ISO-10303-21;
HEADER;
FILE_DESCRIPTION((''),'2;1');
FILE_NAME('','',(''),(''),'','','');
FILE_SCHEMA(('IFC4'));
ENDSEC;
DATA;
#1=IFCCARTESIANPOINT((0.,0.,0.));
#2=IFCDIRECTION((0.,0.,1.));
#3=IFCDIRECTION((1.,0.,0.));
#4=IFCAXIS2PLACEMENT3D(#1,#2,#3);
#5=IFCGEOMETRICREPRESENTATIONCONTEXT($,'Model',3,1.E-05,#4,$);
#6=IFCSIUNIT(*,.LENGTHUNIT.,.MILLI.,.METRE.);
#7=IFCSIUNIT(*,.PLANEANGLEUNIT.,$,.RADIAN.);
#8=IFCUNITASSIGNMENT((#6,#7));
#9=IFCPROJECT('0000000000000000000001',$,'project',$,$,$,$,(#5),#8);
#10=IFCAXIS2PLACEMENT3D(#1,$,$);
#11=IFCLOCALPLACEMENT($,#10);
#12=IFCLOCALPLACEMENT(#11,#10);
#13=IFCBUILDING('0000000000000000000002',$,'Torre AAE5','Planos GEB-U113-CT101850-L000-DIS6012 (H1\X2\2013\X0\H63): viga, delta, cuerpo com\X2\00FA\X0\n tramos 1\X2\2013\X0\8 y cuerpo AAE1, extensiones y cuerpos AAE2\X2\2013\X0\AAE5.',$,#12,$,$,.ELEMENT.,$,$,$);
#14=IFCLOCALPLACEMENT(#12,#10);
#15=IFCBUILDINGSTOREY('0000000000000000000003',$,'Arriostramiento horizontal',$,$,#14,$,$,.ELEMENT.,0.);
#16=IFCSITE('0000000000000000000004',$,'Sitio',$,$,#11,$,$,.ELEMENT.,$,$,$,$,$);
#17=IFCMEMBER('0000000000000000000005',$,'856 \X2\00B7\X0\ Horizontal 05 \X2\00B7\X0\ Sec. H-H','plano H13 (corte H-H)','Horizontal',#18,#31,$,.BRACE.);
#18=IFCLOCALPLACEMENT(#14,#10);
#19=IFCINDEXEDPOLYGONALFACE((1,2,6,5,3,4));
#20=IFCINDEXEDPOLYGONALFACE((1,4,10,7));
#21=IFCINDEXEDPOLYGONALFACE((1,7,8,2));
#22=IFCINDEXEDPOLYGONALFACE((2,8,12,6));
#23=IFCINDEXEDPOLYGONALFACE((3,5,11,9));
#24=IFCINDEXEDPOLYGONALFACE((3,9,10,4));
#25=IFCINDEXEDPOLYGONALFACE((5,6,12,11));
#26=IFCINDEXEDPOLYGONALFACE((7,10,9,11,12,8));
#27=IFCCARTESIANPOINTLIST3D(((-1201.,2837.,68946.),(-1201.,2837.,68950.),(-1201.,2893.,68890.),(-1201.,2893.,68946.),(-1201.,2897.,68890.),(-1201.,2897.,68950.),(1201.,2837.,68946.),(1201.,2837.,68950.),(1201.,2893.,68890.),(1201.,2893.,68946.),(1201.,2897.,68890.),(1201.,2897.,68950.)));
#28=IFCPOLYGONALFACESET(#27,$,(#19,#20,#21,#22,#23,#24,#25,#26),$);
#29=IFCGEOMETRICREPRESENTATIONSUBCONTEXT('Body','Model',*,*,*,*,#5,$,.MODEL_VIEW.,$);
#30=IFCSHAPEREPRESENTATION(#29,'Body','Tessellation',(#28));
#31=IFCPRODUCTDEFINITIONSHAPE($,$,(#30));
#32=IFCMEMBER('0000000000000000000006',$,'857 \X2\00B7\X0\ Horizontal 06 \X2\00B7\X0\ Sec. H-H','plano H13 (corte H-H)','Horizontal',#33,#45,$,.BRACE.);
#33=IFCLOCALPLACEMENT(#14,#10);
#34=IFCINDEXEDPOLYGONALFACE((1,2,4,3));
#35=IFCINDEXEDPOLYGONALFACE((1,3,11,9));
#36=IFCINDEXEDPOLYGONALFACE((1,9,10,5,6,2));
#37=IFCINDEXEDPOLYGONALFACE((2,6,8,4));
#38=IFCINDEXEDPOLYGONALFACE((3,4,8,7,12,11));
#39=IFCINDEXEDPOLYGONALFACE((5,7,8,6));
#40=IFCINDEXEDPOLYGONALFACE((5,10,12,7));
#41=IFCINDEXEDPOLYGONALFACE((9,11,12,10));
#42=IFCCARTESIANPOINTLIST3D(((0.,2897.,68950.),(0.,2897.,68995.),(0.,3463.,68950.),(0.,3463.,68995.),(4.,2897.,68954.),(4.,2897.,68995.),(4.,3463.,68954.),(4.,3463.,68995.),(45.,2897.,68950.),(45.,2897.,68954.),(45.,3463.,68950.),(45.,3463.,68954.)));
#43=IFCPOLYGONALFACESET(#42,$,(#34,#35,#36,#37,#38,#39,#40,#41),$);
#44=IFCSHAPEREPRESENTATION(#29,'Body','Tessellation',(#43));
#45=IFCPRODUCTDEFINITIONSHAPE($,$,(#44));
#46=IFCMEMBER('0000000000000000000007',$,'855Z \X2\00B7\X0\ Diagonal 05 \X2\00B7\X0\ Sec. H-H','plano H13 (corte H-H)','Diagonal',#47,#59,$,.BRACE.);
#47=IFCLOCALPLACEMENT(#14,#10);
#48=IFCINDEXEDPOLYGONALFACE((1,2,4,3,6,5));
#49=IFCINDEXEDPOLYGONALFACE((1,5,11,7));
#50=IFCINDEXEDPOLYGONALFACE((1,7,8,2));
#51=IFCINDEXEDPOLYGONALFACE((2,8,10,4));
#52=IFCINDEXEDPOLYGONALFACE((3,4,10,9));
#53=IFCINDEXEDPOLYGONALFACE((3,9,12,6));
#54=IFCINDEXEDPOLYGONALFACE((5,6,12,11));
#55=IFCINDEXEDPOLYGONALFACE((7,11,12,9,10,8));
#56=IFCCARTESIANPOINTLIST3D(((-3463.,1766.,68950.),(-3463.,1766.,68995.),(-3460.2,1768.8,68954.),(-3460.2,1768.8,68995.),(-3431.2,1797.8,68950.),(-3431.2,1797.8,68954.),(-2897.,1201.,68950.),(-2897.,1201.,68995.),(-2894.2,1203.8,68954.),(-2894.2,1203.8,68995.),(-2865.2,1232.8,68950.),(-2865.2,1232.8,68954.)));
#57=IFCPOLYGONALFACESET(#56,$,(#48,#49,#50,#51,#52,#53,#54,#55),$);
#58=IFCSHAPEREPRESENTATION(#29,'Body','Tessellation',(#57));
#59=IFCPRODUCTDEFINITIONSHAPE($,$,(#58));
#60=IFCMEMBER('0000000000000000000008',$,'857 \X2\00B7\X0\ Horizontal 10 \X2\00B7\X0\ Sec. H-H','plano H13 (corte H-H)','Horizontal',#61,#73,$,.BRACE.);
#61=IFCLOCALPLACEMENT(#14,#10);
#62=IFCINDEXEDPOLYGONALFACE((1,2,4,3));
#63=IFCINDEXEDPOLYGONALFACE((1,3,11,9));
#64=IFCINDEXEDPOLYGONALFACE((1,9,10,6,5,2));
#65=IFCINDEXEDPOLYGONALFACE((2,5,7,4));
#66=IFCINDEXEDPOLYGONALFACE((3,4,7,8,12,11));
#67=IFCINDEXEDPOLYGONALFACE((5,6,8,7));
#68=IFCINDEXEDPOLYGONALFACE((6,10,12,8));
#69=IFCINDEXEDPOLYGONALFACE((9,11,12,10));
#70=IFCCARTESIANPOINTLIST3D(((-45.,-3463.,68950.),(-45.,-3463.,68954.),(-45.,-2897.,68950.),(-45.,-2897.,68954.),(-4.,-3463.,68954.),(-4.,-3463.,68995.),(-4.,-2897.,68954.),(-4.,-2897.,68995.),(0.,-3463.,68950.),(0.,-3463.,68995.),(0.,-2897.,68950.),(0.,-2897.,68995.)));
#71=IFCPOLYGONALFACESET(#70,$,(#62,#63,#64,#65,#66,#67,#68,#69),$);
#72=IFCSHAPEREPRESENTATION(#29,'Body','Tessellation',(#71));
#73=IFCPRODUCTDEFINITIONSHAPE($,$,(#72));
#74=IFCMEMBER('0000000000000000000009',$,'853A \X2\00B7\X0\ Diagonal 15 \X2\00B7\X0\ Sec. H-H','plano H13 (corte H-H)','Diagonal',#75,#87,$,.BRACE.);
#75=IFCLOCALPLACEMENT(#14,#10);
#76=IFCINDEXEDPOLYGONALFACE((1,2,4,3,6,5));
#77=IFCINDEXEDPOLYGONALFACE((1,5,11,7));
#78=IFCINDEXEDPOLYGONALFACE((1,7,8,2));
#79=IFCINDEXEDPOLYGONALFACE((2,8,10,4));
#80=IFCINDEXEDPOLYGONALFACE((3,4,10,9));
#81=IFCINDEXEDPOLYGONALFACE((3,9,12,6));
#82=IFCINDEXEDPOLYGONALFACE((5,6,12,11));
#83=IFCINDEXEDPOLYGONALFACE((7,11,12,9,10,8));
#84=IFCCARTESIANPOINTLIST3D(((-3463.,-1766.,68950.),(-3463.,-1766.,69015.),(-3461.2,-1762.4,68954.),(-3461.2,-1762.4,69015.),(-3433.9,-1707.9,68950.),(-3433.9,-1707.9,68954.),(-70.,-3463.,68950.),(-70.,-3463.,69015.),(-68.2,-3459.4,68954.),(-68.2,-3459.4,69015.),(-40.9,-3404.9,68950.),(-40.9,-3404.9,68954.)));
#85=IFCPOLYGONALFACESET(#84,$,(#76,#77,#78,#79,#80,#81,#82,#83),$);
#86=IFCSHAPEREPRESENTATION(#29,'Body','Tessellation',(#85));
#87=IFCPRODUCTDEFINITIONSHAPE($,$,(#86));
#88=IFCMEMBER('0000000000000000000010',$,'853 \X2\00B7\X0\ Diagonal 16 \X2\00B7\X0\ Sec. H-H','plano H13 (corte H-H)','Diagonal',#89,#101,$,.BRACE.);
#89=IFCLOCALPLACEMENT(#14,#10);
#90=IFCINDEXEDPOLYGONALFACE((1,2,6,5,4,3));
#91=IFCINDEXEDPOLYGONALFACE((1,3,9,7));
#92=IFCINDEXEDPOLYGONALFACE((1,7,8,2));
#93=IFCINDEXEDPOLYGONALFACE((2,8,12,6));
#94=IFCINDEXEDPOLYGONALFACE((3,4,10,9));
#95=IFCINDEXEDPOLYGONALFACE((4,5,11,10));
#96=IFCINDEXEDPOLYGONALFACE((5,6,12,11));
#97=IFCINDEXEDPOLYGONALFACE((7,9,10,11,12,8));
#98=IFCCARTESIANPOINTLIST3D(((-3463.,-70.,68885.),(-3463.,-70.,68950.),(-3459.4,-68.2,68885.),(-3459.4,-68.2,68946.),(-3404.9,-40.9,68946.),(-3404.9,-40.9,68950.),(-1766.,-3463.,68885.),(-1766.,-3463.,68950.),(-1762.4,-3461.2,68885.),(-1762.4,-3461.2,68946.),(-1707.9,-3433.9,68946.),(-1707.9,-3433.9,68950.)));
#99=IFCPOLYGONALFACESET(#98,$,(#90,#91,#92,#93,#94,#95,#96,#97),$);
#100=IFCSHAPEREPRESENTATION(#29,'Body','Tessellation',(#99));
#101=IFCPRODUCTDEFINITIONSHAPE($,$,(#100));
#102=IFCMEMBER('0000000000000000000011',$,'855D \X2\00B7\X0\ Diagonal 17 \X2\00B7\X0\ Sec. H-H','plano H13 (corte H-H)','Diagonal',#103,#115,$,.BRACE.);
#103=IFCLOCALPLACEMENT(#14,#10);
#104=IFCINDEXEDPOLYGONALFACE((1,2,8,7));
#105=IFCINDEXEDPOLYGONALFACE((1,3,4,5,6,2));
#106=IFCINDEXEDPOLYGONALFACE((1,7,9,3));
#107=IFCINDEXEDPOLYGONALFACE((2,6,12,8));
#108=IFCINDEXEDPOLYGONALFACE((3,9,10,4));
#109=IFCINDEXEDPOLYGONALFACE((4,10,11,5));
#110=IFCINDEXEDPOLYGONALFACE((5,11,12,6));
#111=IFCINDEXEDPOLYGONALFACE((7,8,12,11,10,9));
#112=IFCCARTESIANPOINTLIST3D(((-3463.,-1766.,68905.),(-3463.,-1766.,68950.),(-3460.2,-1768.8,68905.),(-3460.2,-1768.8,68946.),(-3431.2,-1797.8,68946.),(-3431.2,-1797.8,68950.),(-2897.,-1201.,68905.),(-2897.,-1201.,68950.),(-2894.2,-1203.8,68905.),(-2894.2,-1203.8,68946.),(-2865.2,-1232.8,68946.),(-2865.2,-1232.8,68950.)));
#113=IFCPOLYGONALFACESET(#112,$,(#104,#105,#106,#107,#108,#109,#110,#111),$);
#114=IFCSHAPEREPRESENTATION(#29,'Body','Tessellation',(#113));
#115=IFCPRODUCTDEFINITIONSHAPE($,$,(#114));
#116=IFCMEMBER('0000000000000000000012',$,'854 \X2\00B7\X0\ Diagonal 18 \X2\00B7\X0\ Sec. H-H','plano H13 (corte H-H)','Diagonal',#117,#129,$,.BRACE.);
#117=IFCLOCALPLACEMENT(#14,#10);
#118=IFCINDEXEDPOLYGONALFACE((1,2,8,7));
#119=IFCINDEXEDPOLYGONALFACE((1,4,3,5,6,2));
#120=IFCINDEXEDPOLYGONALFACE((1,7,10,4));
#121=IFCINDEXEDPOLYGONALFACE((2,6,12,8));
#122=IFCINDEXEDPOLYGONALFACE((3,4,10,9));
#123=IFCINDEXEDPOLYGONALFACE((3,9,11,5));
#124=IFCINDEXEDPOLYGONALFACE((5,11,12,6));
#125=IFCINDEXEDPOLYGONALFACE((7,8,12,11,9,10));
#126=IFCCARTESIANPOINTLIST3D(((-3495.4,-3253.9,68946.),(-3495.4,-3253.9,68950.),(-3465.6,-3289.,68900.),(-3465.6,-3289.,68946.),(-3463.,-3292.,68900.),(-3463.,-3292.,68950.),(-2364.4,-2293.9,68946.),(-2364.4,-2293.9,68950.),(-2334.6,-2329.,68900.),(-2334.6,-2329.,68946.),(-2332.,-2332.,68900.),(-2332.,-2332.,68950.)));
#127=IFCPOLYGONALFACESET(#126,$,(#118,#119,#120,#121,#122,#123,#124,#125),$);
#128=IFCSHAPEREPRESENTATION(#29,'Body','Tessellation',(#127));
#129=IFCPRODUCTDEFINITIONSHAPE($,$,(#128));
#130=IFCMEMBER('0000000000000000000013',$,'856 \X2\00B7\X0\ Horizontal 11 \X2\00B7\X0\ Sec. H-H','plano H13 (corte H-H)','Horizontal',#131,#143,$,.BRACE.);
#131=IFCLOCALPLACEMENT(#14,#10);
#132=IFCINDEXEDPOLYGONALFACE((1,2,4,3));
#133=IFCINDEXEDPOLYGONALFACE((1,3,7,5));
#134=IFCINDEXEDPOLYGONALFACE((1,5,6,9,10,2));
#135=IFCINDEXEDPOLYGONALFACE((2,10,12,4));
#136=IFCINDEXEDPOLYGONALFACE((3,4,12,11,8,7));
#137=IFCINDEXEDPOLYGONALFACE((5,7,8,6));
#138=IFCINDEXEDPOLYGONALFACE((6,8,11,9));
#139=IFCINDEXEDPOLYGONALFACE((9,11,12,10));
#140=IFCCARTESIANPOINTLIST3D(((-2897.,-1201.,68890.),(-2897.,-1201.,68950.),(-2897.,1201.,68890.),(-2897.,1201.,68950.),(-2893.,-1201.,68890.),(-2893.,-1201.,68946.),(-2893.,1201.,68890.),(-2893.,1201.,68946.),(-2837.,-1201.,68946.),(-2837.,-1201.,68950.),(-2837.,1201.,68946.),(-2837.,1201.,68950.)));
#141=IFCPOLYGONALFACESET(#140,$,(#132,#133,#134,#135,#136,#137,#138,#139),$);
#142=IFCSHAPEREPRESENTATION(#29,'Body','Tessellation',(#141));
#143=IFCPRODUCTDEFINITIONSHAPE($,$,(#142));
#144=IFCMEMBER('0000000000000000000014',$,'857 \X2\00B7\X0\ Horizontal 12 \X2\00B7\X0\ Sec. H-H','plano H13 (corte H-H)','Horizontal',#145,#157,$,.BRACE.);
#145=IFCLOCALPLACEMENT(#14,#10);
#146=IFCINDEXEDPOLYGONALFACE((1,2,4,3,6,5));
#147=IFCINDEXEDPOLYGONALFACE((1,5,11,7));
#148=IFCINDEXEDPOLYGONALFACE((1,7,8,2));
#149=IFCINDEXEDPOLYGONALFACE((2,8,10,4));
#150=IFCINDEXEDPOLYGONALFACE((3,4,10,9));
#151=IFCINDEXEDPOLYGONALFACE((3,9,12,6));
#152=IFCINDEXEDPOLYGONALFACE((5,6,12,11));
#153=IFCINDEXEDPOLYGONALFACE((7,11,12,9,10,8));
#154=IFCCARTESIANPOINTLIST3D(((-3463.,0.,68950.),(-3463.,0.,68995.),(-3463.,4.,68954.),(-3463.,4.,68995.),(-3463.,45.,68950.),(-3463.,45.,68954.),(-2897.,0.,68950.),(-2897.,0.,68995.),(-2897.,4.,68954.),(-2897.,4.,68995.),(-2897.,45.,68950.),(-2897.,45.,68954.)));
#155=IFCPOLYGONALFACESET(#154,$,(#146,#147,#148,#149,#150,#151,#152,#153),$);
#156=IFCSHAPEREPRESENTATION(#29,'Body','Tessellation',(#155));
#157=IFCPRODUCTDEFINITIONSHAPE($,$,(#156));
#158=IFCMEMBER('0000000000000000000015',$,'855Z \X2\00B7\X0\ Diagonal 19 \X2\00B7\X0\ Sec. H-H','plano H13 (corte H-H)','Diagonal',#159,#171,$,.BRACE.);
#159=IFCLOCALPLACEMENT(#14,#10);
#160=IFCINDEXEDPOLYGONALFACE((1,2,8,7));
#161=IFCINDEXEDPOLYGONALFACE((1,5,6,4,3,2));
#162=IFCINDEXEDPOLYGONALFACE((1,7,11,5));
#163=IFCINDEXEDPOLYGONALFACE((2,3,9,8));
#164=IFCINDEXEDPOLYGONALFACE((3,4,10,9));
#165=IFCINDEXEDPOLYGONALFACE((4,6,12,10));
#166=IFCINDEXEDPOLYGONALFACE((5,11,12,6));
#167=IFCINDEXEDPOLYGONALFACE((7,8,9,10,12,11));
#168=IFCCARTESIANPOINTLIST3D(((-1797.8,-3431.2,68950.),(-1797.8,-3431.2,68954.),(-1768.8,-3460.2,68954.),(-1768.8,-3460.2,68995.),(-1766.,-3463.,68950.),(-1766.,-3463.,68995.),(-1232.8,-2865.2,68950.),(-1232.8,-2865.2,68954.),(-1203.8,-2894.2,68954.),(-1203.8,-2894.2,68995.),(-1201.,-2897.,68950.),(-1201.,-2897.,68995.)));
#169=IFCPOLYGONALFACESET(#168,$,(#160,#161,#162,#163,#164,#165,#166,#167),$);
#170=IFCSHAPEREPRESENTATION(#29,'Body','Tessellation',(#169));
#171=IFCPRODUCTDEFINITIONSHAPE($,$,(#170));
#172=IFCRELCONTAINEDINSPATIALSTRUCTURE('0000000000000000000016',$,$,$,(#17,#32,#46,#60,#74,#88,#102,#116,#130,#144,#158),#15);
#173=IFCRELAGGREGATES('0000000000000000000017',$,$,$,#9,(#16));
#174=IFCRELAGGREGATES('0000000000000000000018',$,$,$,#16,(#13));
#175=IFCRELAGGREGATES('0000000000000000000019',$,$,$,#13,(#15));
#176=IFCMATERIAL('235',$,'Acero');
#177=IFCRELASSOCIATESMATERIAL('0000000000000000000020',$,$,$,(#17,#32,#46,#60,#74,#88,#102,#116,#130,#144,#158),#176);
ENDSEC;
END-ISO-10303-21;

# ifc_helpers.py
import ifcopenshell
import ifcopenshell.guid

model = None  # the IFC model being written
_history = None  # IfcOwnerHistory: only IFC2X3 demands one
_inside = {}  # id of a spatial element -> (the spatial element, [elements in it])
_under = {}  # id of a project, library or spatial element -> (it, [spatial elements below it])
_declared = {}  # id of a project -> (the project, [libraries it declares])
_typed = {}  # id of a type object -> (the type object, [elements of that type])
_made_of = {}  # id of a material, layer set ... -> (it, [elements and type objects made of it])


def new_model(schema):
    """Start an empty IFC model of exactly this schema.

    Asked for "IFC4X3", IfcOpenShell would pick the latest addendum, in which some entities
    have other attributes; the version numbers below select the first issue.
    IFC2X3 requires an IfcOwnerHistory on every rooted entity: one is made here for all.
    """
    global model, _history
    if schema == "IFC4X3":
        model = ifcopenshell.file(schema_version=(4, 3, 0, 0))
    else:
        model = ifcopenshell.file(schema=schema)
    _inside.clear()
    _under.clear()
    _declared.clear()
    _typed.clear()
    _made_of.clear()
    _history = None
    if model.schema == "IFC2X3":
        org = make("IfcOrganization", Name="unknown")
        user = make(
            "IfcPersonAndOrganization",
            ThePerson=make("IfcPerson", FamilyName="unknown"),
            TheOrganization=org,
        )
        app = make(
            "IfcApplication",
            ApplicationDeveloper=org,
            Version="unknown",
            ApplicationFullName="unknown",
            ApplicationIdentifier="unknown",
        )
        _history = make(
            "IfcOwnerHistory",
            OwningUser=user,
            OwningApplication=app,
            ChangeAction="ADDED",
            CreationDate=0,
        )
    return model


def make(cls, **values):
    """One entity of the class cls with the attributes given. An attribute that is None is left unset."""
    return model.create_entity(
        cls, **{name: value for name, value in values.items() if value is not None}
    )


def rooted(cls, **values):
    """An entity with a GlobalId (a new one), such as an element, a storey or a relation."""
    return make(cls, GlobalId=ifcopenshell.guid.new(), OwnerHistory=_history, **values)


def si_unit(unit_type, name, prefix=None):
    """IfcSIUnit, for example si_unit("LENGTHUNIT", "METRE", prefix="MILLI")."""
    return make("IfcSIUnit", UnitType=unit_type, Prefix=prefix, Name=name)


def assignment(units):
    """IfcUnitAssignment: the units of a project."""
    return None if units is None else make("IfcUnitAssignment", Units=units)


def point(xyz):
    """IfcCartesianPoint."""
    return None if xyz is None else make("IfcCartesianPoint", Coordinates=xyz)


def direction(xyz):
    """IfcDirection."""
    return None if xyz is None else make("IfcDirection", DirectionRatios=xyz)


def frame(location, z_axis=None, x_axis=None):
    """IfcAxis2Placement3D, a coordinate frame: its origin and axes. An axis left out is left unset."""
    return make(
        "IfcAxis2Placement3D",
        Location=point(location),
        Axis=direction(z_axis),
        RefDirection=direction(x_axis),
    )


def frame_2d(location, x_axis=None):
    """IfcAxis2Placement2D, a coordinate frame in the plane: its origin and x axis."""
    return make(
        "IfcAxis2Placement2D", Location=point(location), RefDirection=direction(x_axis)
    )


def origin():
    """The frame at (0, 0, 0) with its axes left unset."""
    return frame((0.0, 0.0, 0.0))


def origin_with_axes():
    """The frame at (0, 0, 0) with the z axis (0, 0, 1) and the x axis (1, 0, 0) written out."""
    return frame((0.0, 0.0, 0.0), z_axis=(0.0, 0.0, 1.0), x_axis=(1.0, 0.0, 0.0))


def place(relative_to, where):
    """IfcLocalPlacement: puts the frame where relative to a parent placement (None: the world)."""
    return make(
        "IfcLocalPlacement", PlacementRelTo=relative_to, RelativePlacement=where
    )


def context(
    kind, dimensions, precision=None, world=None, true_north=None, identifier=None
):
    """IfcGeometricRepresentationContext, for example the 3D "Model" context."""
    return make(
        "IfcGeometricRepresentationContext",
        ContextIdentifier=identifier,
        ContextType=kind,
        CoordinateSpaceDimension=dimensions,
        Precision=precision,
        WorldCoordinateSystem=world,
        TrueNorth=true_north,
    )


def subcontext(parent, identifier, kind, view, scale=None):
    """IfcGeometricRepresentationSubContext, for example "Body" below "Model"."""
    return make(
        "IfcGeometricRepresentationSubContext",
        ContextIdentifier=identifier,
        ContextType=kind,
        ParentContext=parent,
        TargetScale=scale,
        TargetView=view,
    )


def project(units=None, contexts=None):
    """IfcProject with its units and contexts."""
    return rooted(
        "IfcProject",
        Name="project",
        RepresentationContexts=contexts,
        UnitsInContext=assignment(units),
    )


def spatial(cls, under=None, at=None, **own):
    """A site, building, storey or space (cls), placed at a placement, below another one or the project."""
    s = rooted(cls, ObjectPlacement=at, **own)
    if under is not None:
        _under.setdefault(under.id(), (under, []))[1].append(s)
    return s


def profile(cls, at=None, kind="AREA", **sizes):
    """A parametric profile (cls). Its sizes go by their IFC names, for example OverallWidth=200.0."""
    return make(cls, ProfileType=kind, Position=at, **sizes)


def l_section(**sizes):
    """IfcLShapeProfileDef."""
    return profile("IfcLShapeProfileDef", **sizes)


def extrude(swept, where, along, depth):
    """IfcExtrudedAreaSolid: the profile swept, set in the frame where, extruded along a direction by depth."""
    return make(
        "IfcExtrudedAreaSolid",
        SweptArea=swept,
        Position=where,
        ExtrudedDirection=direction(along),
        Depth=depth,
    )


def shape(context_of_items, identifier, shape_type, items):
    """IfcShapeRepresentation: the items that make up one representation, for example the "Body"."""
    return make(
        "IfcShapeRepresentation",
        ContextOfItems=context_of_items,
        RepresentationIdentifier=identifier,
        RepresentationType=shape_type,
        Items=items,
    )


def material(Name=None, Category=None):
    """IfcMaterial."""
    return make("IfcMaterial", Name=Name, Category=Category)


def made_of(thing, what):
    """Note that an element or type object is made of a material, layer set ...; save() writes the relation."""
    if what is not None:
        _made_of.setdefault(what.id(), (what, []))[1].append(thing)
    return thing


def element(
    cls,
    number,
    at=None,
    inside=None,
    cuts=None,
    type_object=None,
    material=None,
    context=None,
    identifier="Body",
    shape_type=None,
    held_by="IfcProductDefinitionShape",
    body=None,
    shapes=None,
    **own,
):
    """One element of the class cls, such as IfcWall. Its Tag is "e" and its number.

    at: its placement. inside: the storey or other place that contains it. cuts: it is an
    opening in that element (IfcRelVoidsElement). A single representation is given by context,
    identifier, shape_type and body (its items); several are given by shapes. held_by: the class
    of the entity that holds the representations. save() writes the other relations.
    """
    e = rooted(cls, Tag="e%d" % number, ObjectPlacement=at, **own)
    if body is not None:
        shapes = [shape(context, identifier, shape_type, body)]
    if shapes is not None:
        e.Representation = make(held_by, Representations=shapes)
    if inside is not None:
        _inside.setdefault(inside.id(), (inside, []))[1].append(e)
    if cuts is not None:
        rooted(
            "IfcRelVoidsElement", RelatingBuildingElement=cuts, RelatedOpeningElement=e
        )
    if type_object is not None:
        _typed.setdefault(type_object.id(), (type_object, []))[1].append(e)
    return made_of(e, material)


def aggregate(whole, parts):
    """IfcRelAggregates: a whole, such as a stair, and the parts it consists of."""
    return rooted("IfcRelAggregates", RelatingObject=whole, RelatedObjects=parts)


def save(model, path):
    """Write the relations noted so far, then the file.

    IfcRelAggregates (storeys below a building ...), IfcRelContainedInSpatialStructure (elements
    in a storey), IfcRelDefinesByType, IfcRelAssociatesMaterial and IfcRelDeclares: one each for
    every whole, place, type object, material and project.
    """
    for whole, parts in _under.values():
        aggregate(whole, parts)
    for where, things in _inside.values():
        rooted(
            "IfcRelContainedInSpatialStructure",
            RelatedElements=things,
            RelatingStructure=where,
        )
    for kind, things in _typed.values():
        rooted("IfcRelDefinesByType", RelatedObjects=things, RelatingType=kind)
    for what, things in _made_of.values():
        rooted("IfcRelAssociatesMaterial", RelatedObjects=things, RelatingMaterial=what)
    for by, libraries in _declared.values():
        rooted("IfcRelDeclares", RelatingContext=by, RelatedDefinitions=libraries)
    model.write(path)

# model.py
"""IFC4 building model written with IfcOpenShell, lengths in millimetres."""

from ifc_helpers import new_model, si_unit, frame, frame_2d, origin, origin_with_axes, place, context, subcontext, project, spatial, l_section, extrude, material, element, save


model = new_model("IFC4")

# Units and contexts
model_context = context("Model", 3, precision=1e-05, world=origin_with_axes())
body_context = subcontext(model_context, "Body", "Model", "MODEL_VIEW")
ifc_project = project(units=[si_unit("LENGTHUNIT", "METRE", prefix="MILLI"), si_unit("PLANEANGLEUNIT", "RADIAN")], contexts=[model_context])

# Site, building, storey
site_placement = place(None, origin())
site = spatial("IfcSite", under=ifc_project, at=site_placement, Name="Sitio", CompositionType="ELEMENT")
building_placement = place(site_placement, origin())
building = spatial("IfcBuilding", under=site, at=building_placement, Name="Torre AAE5", Description="Planos GEB-U113-CT101850-L000-DIS6012 (H1–H63): viga, delta, cuerpo común tramos 1–8 y cuerpo AAE1, extensiones y cuerpos AAE2–AAE5.", CompositionType="ELEMENT")
storey_placement = place(building_placement, origin())
storey = spatial("IfcBuildingStorey", under=building, at=storey_placement, Name="Arriostramiento horizontal", CompositionType="ELEMENT", Elevation=0.0)

# Members
ifc_material_1 = material(Name="235", Category="Acero")
member_1_placement = place(storey_placement, frame((-1201.0, 2897.0, 68950.0), z_axis=(1.0, 0.0, 0.0), x_axis=(0.0, -1.0, 0.0)))
element("IfcMember", 1, at=member_1_placement, inside=storey, material=ifc_material_1, Name="856 · Horizontal 05 · Sec. H-H", Description="plano H13 (corte H-H)", ObjectType="Horizontal", PredefinedType="BRACE", context=body_context, shape_type="SweptSolid", body=[
    extrude(l_section(Depth=60.0, Width=60.0, Thickness=4.0, at=frame_2d((30.0, 30.0))), None, (0.0, 0.0, 1.0), 2402.0),
])
member_2_placement = place(storey_placement, frame((0.0, 2897.0, 68950.0), z_axis=(0.0, 1.0, 0.0), x_axis=(0.0, 0.0, 1.0)))
element("IfcMember", 2, at=member_2_placement, inside=storey, material=ifc_material_1, Name="857 · Horizontal 06 · Sec. H-H", Description="plano H13 (corte H-H)", ObjectType="Horizontal", PredefinedType="BRACE", context=body_context, shape_type="SweptSolid", body=[
    extrude(l_section(Depth=45.0, Width=45.0, Thickness=4.0, at=frame_2d((22.5, 22.5))), None, (0.0, 0.0, 1.0), 566.0),
])
member_3_placement = place(storey_placement, frame((-3463.0, 1766.0, 68950.0), z_axis=(0.707732, -0.706481, 0.0), x_axis=(0.706481, 0.707732, 0.0)))
element("IfcMember", 3, at=member_3_placement, inside=storey, material=ifc_material_1, Name="855Z · Diagonal 05 · Sec. H-H", Description="plano H13 (corte H-H)", ObjectType="Diagonal", PredefinedType="BRACE", context=body_context, shape_type="SweptSolid", body=[
    extrude(l_section(Depth=45.0, Width=45.0, Thickness=4.0, at=frame_2d((22.5, 22.5))), None, (0.0, 0.0, 1.0), 799.7),
])
member_4_placement = place(storey_placement, frame((0.0, -2897.0, 68950.0), z_axis=(0.0, -1.0, 0.0), x_axis=(0.0, 0.0, 1.0)))
element("IfcMember", 4, at=member_4_placement, inside=storey, material=ifc_material_1, Name="857 · Horizontal 10 · Sec. H-H", Description="plano H13 (corte H-H)", ObjectType="Horizontal", PredefinedType="BRACE", context=body_context, shape_type="SweptSolid", body=[
    extrude(l_section(Depth=45.0, Width=45.0, Thickness=4.0, at=frame_2d((22.5, 22.5))), None, (0.0, 0.0, 1.0), 566.0),
])
for number, where, z_axis, x_axis, name in (
    (5, (-3463.0, -1766.0, 68950.0), (0.894374, -0.447319, 0.0), (0.447319, 0.894374, 0.0), "853A · Diagonal 15 · Sec. H-H"),
    (6, (-1766.0, -3463.0, 68950.0), (-0.447319, 0.894374, 0.0), (0.894374, 0.447319, 0.0), "853 · Diagonal 16 · Sec. H-H"),
):
    element("IfcMember", number, at=place(storey_placement, frame(where, z_axis=z_axis, x_axis=x_axis)), inside=storey, material=ifc_material_1, Name=name, Description="plano H13 (corte H-H)", ObjectType="Diagonal", PredefinedType="BRACE", context=body_context, shape_type="SweptSolid", body=[
        extrude(l_section(Depth=65.0, Width=65.0, Thickness=4.0, at=frame_2d((32.5, 32.5))), None, (0.0, 0.0, 1.0), 3793.7),
    ])
member_5_placement = place(storey_placement, frame((-3463.0, -1766.0, 68950.0), z_axis=(0.707732, 0.706481, 0.0), x_axis=(0.706481, -0.707732, 0.0)))
element("IfcMember", 7, at=member_5_placement, inside=storey, material=ifc_material_1, Name="855D · Diagonal 17 · Sec. H-H", Description="plano H13 (corte H-H)", ObjectType="Diagonal", PredefinedType="BRACE", context=body_context, shape_type="SweptSolid", body=[
    extrude(l_section(Depth=45.0, Width=45.0, Thickness=4.0, at=frame_2d((22.5, 22.5))), None, (0.0, 0.0, 1.0), 799.7),
])
member_6_placement = place(storey_placement, frame((-2332.0, -2332.0, 68950.0), z_axis=(-0.762388, -0.64712, 0.0), x_axis=(-0.64712, 0.762388, 0.0)))
element("IfcMember", 8, at=member_6_placement, inside=storey, material=ifc_material_1, Name="854 · Diagonal 18 · Sec. H-H", Description="plano H13 (corte H-H)", ObjectType="Diagonal", PredefinedType="BRACE", context=body_context, shape_type="SweptSolid", body=[
    extrude(l_section(Depth=50.0, Width=50.0, Thickness=4.0, at=frame_2d((25.0, 25.0))), None, (0.0, 0.0, 1.0), 1483.5),
])
member_7_placement = place(storey_placement, frame((-2897.0, -1201.0, 68950.0), z_axis=(0.0, 1.0, 0.0), x_axis=(1.0, 0.0, 0.0)))
element("IfcMember", 9, at=member_7_placement, inside=storey, material=ifc_material_1, Name="856 · Horizontal 11 · Sec. H-H", Description="plano H13 (corte H-H)", ObjectType="Horizontal", PredefinedType="BRACE", context=body_context, shape_type="SweptSolid", body=[
    extrude(l_section(Depth=60.0, Width=60.0, Thickness=4.0, at=frame_2d((30.0, 30.0))), None, (0.0, 0.0, 1.0), 2402.0),
])
member_8_placement = place(storey_placement, frame((-2897.0, 0.0, 68950.0), z_axis=(-1.0, 0.0, 0.0), x_axis=(0.0, 0.0, 1.0)))
element("IfcMember", 10, at=member_8_placement, inside=storey, material=ifc_material_1, Name="857 · Horizontal 12 · Sec. H-H", Description="plano H13 (corte H-H)", ObjectType="Horizontal", PredefinedType="BRACE", context=body_context, shape_type="SweptSolid", body=[
    extrude(l_section(Depth=45.0, Width=45.0, Thickness=4.0, at=frame_2d((22.5, 22.5))), None, (0.0, 0.0, 1.0), 566.0),
])
member_9_placement = place(storey_placement, frame((-1766.0, -3463.0, 68950.0), z_axis=(0.706481, 0.707732, 0.0), x_axis=(-0.707732, 0.706481, 0.0)))
element("IfcMember", 11, at=member_9_placement, inside=storey, material=ifc_material_1, Name="855Z · Diagonal 19 · Sec. H-H", Description="plano H13 (corte H-H)", ObjectType="Diagonal", PredefinedType="BRACE", context=body_context, shape_type="SweptSolid", body=[
    extrude(l_section(Depth=45.0, Width=45.0, Thickness=4.0, at=frame_2d((22.5, 22.5))), None, (0.0, 0.0, 1.0), 799.7),
])

save(model, "model.ifc")
